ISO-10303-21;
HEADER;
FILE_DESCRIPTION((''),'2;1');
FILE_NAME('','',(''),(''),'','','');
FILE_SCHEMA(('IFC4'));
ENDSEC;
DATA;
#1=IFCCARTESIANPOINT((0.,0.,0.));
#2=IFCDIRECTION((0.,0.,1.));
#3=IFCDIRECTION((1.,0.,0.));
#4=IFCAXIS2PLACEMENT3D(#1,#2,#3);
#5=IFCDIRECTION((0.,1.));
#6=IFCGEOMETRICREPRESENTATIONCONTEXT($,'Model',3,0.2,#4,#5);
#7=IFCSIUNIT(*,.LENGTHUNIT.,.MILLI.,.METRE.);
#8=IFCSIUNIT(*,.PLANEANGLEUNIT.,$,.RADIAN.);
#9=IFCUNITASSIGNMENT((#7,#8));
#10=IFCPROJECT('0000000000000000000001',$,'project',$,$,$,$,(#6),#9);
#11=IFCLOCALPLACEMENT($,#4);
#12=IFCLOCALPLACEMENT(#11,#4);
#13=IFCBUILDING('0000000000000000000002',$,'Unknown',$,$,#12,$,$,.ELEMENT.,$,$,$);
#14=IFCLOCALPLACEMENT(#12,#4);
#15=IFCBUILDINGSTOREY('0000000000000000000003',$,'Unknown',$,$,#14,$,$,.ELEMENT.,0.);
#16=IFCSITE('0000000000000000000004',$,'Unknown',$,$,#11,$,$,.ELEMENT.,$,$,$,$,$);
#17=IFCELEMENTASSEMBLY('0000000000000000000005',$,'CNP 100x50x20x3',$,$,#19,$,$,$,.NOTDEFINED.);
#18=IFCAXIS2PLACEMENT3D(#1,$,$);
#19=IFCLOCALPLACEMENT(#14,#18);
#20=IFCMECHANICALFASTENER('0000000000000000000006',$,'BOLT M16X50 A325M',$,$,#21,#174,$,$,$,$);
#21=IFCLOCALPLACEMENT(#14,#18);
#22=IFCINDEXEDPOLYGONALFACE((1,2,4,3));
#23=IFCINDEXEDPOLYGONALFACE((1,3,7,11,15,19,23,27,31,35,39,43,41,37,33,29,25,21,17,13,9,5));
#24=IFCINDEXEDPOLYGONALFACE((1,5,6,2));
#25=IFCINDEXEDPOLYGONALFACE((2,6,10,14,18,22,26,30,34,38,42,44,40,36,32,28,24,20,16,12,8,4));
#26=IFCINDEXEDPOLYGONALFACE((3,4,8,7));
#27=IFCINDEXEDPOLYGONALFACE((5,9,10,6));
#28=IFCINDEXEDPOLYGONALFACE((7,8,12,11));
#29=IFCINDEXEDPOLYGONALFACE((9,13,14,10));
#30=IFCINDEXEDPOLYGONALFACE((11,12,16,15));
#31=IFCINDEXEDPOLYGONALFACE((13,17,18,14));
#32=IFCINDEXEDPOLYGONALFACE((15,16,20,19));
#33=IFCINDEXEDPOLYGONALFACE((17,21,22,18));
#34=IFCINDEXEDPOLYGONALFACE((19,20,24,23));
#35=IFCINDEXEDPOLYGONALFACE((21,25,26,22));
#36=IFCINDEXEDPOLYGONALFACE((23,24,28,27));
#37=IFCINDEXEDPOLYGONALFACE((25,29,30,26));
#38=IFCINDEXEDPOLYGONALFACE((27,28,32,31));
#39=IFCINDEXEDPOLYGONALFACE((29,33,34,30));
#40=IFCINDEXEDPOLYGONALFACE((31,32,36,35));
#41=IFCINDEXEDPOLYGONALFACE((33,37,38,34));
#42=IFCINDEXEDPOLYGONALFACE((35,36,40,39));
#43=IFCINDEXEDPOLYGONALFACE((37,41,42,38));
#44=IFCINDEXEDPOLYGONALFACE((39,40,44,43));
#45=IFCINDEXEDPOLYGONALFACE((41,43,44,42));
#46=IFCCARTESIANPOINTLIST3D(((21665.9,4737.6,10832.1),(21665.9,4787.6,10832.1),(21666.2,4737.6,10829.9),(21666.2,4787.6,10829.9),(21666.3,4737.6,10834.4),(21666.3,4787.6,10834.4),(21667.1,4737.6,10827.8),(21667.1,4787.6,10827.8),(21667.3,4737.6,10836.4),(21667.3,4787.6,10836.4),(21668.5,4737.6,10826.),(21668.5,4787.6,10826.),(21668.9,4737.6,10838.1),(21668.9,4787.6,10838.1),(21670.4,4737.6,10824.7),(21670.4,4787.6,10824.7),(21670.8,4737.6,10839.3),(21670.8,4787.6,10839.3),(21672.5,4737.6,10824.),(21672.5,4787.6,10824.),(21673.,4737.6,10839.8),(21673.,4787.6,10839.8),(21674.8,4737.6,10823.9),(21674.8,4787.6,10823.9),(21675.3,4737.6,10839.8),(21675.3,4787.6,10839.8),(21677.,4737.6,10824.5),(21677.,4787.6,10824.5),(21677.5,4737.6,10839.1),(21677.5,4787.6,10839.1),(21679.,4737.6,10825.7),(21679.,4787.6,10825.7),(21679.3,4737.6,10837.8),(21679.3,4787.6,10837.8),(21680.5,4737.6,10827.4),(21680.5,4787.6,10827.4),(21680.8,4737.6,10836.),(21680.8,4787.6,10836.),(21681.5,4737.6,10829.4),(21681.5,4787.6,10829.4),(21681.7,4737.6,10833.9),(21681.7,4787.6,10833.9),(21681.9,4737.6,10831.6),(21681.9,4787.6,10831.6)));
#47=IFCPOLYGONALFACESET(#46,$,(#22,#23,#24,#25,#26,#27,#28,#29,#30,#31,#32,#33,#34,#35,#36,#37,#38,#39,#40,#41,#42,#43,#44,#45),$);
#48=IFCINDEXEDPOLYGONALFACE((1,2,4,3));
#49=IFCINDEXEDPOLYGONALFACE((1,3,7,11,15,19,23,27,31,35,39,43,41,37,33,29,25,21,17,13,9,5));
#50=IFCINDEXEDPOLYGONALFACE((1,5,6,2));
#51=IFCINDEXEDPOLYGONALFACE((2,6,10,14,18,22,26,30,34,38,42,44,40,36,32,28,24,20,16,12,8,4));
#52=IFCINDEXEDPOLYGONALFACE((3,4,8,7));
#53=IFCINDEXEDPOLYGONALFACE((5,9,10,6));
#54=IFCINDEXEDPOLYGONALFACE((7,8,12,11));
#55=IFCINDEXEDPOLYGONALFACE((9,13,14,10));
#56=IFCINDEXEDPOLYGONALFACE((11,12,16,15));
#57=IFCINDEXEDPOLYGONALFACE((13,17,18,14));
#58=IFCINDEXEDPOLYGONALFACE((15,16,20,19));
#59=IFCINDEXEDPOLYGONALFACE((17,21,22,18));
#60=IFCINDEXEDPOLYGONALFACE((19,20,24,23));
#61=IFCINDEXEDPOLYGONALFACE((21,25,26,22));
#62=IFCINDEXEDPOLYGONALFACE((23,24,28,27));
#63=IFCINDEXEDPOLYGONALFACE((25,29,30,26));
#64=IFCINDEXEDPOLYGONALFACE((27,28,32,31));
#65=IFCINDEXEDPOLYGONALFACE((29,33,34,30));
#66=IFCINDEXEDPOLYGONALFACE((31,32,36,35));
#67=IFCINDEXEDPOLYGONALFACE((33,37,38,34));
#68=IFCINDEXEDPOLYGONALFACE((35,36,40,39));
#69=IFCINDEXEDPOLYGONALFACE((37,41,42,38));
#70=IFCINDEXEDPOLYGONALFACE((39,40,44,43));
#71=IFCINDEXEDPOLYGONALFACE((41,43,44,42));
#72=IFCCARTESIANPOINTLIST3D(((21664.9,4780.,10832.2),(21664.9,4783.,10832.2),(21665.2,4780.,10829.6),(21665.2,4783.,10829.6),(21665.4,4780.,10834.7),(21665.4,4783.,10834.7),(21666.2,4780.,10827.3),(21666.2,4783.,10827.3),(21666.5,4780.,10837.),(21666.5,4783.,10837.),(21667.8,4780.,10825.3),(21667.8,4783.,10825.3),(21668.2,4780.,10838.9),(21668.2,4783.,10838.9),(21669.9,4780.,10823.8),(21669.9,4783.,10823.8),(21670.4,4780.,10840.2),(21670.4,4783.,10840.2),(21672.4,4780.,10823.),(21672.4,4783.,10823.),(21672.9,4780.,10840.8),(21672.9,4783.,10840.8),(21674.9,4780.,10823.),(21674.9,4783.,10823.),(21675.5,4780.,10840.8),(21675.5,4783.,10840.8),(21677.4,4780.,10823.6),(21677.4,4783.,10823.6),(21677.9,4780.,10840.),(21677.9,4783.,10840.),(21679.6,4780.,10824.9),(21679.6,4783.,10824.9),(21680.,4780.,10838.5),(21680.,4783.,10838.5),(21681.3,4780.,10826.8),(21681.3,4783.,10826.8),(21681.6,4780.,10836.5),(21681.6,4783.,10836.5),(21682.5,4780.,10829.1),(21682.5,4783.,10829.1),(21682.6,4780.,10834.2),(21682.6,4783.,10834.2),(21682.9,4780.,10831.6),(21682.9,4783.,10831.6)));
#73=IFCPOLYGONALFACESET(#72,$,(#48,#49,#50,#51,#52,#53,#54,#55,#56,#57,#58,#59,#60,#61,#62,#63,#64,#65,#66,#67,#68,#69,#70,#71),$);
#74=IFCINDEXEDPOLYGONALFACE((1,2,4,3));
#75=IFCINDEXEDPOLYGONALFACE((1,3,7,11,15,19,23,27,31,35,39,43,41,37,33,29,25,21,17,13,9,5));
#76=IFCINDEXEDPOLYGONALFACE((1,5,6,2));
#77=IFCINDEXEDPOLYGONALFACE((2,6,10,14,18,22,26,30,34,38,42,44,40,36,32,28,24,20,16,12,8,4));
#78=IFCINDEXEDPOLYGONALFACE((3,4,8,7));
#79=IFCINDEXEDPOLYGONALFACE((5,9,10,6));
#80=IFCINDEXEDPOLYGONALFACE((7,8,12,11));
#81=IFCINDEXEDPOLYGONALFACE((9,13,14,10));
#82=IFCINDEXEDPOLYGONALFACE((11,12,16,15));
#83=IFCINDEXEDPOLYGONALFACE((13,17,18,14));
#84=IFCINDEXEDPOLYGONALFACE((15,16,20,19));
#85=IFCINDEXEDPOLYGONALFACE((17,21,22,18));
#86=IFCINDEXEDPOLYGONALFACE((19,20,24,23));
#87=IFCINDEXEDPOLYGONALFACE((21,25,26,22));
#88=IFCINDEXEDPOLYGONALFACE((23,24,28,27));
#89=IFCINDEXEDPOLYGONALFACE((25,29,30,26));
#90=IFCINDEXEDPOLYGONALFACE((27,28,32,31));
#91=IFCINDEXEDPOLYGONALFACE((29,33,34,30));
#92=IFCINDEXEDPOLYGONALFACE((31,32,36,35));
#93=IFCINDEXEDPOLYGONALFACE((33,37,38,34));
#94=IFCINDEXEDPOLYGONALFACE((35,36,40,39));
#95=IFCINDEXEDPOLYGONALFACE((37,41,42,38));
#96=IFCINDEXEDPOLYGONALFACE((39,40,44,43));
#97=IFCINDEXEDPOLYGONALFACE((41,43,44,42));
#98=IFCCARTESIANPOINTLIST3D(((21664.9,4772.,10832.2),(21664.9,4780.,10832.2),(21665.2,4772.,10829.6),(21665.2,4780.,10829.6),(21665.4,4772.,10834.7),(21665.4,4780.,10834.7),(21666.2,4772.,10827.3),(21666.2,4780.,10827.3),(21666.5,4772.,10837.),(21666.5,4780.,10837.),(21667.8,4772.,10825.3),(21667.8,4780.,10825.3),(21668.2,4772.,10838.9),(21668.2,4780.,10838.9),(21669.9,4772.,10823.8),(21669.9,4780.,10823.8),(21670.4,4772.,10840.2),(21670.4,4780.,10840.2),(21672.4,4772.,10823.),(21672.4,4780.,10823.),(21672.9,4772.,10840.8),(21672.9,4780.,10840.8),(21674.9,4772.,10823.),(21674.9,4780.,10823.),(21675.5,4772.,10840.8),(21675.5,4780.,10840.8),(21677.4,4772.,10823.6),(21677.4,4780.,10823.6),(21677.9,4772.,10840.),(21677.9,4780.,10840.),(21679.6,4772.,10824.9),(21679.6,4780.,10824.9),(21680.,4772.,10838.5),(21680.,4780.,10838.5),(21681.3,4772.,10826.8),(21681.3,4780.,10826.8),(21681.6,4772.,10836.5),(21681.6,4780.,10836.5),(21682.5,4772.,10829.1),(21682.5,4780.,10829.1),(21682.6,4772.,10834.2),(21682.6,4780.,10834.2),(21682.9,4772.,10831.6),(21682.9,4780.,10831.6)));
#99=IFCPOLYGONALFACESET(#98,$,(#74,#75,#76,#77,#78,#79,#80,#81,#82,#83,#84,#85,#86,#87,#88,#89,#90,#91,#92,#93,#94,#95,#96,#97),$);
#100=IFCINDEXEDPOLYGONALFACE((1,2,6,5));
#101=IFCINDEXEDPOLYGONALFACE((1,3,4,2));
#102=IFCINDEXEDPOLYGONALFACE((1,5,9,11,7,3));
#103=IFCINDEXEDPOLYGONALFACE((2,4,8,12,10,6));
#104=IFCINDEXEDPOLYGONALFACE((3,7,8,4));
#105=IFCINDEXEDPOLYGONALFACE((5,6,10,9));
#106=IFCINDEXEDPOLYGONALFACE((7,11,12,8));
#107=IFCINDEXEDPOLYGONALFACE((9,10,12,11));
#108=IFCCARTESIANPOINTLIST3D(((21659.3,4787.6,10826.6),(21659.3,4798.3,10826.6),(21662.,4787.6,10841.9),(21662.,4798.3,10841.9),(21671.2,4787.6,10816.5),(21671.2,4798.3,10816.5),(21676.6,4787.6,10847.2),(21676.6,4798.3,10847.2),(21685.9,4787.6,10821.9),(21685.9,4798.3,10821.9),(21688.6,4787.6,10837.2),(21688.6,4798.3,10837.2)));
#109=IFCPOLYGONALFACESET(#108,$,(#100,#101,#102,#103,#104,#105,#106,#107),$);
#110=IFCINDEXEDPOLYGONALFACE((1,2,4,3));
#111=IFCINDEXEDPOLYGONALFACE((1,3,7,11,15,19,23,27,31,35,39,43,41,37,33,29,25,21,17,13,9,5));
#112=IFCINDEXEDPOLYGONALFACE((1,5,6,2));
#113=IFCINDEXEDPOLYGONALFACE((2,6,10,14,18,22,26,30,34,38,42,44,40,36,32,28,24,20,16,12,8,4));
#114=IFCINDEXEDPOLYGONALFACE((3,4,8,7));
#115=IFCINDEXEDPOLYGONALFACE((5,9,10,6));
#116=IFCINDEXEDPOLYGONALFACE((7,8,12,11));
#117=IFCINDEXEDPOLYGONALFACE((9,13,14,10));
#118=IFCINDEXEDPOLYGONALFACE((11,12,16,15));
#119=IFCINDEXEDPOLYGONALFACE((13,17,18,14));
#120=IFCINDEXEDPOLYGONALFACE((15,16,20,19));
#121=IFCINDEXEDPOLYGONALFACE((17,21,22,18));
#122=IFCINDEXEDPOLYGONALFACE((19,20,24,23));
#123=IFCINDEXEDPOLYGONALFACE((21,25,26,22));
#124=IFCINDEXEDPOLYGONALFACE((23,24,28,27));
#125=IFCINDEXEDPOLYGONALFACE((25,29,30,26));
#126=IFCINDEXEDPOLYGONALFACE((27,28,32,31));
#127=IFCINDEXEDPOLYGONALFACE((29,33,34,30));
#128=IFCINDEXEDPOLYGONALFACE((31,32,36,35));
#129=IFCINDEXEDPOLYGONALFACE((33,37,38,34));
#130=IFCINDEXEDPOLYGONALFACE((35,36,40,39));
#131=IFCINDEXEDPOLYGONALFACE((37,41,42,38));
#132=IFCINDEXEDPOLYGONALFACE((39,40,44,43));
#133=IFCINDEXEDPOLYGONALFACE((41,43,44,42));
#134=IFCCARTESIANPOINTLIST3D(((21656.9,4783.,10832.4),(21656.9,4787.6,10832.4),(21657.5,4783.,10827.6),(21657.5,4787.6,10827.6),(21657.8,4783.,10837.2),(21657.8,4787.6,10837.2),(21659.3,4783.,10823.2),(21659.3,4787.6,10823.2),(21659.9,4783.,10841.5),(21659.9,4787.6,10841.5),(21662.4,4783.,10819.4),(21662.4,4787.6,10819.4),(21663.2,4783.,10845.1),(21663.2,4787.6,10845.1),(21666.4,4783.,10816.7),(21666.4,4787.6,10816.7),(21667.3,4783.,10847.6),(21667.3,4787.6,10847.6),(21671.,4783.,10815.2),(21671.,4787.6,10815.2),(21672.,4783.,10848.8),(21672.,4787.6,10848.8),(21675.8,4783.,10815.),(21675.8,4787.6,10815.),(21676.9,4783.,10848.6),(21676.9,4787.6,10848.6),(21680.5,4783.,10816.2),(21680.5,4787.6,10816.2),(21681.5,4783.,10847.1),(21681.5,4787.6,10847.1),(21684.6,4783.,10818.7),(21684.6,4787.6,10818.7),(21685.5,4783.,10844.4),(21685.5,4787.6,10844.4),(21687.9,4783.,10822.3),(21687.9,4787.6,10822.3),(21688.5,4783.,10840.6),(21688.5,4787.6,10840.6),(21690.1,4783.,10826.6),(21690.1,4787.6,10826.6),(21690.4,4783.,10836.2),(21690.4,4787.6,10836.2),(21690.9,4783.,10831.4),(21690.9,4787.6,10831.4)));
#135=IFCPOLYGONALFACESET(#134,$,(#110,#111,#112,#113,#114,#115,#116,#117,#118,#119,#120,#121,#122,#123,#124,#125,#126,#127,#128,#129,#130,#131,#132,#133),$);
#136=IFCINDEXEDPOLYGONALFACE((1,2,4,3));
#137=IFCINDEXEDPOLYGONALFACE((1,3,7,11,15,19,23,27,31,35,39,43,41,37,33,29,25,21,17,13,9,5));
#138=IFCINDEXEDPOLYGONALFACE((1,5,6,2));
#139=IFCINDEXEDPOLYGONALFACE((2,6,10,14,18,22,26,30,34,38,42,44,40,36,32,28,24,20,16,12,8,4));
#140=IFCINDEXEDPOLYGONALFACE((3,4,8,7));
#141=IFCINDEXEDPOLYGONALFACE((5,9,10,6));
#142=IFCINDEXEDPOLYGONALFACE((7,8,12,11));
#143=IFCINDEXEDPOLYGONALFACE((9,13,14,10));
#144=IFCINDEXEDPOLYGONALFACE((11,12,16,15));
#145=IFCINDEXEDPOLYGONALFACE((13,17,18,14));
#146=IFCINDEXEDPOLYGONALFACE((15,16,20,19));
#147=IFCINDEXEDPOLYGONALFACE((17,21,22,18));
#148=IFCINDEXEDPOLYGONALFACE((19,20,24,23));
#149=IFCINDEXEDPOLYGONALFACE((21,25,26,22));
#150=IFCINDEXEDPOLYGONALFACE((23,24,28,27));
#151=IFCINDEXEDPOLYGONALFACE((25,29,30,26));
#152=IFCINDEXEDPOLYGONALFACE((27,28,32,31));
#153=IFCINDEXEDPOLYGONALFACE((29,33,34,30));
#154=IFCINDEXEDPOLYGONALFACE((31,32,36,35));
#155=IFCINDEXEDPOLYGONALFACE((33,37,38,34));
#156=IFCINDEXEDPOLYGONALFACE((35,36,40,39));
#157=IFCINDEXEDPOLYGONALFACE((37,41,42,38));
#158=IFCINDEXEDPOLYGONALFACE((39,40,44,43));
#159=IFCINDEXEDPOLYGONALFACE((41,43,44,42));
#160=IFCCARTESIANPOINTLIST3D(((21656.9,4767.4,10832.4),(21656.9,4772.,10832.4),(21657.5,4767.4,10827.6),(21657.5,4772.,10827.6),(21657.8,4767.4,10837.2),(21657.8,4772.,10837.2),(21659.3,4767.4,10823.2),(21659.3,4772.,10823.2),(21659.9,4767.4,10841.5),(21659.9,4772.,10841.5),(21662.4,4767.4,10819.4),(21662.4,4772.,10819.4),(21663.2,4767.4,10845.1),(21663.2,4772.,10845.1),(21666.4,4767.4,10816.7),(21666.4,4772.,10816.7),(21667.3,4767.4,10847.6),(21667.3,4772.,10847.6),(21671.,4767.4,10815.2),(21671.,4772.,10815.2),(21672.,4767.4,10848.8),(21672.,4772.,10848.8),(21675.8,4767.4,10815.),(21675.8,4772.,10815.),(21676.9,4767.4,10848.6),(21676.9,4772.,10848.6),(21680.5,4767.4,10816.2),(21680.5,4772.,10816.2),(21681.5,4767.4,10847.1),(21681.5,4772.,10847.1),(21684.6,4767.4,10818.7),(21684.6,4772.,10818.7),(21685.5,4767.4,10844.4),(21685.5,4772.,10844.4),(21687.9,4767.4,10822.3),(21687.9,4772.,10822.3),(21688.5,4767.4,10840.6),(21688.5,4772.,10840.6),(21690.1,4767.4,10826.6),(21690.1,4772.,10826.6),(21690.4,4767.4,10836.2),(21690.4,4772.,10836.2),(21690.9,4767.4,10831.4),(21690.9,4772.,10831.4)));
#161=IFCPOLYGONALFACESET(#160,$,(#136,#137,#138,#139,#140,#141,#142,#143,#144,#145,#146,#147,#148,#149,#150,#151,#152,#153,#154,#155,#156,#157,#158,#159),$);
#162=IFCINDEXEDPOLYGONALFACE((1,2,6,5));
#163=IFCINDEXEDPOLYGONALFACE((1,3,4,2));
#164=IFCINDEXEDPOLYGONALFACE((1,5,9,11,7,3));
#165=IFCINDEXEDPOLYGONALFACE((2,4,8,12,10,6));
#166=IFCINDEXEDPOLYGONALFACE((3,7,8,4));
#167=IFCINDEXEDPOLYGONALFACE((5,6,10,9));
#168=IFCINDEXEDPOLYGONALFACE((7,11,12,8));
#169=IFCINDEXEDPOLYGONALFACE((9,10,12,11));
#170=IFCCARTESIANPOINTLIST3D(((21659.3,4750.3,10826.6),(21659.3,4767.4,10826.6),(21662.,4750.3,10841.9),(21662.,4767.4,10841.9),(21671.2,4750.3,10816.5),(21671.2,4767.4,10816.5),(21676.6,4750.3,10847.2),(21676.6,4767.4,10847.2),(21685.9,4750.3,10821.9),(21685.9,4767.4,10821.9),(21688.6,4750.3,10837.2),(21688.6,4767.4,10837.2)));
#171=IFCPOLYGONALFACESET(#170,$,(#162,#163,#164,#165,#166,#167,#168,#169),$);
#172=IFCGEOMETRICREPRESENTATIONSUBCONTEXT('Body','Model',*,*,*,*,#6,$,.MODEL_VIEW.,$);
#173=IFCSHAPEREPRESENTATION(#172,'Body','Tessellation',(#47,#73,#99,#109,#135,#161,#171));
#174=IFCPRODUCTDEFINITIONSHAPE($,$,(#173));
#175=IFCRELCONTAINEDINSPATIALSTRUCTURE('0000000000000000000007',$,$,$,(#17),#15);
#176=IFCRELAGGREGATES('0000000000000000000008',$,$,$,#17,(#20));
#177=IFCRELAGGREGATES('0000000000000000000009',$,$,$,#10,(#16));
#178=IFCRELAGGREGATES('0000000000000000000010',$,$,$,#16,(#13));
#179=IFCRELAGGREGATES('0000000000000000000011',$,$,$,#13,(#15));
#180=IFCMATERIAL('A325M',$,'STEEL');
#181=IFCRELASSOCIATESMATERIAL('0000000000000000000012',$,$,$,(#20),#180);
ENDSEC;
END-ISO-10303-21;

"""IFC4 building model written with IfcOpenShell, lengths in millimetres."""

from ifc_helpers import new_model, si_unit, direction, frame, origin_with_axes, place, context, subcontext, project, spatial, line, arc, indexed_curve, outline, extrude, source, transform, mapped, material, element, aggregate, save


model = new_model("IFC4")

# Units and contexts
model_context = context("Model", 3, precision=0.2, world=origin_with_axes(), true_north=direction((0.0, 1.0)))
body_context = subcontext(model_context, "Body", "Model", "MODEL_VIEW")
ifc_project = project(units=[si_unit("LENGTHUNIT", "METRE", prefix="MILLI"), si_unit("PLANEANGLEUNIT", "RADIAN")], contexts=[model_context])

# Site, building, storey
site_placement = place(None, origin_with_axes())
site = spatial("IfcSite", under=ifc_project, at=site_placement, Name="Unknown", CompositionType="ELEMENT")
building_placement = place(site_placement, origin_with_axes())
building = spatial("IfcBuilding", under=site, at=building_placement, Name="Unknown", CompositionType="ELEMENT")
storey_placement = place(building_placement, origin_with_axes())
storey = spatial("IfcBuildingStorey", under=building, at=storey_placement, Name="Unknown", CompositionType="ELEMENT", Elevation=0.0)

# Shared definitions
ifc_material_1 = material(Name="A325M", Category="STEEL")
shared_shape = source(origin_with_axes(), body_context, "Body", "SweptSolid", [
    extrude(outline(indexed_curve([(8.0, 0.0), (0.0, 8.0), (-8.0, 0.0), (0.0, -8.0)], segments=[arc(1, 2, 3), arc(3, 4, 1)])), frame((0.0, 0.0, 15.6), z_axis=(0.0, 0.0, -1.0), x_axis=(0.0, 1.0, 0.0)), (0.0, 0.0, 1.0), 50.0),
    extrude(outline(indexed_curve([(9.0, 0.0), (0.0, 9.0), (-9.0, 0.0), (0.0, -9.0)], segments=[arc(1, 2, 3), arc(3, 4, 1)])), frame((0.0, 0.0, 11.0), z_axis=(0.0, 0.0, -1.0), x_axis=(0.0, 1.0, 0.0)), (0.0, 0.0, 1.0), 3.0),
    extrude(outline(indexed_curve([(9.0, 0.0), (0.0, 9.0), (-9.0, 0.0), (0.0, -9.0)], segments=[arc(1, 2, 3), arc(3, 4, 1)])), frame((0.0, 0.0, 8.0), z_axis=(0.0, 0.0, -1.0), x_axis=(0.0, 1.0, 0.0)), (0.0, 0.0, 1.0), 8.0),
    extrude(outline(indexed_curve([(15.6, 0.0), (7.8, 13.5), (-7.8, 13.5), (-15.6, 0.0), (-7.8, -13.5), (7.8, -13.5)], segments=[line(1, 2, 3, 4, 5, 6, 1)])), frame((0.0, 0.0, 26.4), z_axis=(0.0, 0.0, -1.0), x_axis=(0.0, 1.0, 0.0)), (0.0, 0.0, 1.0), 10.8),
    extrude(outline(indexed_curve([(17.0, 0.0), (0.0, 17.0), (-17.0, 0.0), (0.0, -17.0)], segments=[arc(1, 2, 3), arc(3, 4, 1)])), frame((0.0, 0.0, 15.6), z_axis=(0.0, 0.0, -1.0), x_axis=(0.0, 1.0, 0.0)), (0.0, 0.0, 1.0), 4.6),
    extrude(outline(indexed_curve([(17.0, 0.0), (0.0, 17.0), (-17.0, 0.0), (0.0, -17.0)], segments=[arc(1, 2, 3), arc(3, 4, 1)])), frame((0.0, 0.0, 0.0), z_axis=(0.0, 0.0, -1.0), x_axis=(0.0, 1.0, 0.0)), (0.0, 0.0, 1.0), 4.6),
    extrude(outline(indexed_curve([(15.6, 0.0), (7.8, 13.5), (-7.8, 13.5), (-15.6, 0.0), (-7.8, -13.5), (7.8, -13.5)], segments=[line(1, 2, 3, 4, 5, 6, 1)])), frame((0.0, 0.0, -4.6), z_axis=(0.0, 0.0, -1.0), x_axis=(0.0, 1.0, 0.0)), (0.0, 0.0, 1.0), 17.1),
])

# Element assembly, mechanical fastener
assembly_1_placement = place(storey_placement, frame((25552.5, 4805.0, 10153.1), z_axis=(0.173648, 0.0, 0.984808), x_axis=(-0.984808, 0.0, 0.173648)))
assembly_1 = element("IfcElementAssembly", 1, at=assembly_1_placement, inside=storey, Name="CNP 100x50x20x3", PredefinedType="NOTDEFINED")
mechanical_fastener_1_placement = place(assembly_1_placement, frame((3937.5, 33.0, -5.0), z_axis=(0.0, -1.0, 0.0), x_axis=(-1.0, 0.0, 0.0)))
mechanical_fastener_1 = element("IfcMechanicalFastener", 2, at=mechanical_fastener_1_placement, material=ifc_material_1, Name="BOLT M16X50 A325M", context=body_context, shape_type="MappedRepresentation", body=[
    mapped(shared_shape, transform((0.0, 0.0, 0.0))),
])
aggregate(assembly_1, [mechanical_fastener_1])

save(model, "model.ifc")
